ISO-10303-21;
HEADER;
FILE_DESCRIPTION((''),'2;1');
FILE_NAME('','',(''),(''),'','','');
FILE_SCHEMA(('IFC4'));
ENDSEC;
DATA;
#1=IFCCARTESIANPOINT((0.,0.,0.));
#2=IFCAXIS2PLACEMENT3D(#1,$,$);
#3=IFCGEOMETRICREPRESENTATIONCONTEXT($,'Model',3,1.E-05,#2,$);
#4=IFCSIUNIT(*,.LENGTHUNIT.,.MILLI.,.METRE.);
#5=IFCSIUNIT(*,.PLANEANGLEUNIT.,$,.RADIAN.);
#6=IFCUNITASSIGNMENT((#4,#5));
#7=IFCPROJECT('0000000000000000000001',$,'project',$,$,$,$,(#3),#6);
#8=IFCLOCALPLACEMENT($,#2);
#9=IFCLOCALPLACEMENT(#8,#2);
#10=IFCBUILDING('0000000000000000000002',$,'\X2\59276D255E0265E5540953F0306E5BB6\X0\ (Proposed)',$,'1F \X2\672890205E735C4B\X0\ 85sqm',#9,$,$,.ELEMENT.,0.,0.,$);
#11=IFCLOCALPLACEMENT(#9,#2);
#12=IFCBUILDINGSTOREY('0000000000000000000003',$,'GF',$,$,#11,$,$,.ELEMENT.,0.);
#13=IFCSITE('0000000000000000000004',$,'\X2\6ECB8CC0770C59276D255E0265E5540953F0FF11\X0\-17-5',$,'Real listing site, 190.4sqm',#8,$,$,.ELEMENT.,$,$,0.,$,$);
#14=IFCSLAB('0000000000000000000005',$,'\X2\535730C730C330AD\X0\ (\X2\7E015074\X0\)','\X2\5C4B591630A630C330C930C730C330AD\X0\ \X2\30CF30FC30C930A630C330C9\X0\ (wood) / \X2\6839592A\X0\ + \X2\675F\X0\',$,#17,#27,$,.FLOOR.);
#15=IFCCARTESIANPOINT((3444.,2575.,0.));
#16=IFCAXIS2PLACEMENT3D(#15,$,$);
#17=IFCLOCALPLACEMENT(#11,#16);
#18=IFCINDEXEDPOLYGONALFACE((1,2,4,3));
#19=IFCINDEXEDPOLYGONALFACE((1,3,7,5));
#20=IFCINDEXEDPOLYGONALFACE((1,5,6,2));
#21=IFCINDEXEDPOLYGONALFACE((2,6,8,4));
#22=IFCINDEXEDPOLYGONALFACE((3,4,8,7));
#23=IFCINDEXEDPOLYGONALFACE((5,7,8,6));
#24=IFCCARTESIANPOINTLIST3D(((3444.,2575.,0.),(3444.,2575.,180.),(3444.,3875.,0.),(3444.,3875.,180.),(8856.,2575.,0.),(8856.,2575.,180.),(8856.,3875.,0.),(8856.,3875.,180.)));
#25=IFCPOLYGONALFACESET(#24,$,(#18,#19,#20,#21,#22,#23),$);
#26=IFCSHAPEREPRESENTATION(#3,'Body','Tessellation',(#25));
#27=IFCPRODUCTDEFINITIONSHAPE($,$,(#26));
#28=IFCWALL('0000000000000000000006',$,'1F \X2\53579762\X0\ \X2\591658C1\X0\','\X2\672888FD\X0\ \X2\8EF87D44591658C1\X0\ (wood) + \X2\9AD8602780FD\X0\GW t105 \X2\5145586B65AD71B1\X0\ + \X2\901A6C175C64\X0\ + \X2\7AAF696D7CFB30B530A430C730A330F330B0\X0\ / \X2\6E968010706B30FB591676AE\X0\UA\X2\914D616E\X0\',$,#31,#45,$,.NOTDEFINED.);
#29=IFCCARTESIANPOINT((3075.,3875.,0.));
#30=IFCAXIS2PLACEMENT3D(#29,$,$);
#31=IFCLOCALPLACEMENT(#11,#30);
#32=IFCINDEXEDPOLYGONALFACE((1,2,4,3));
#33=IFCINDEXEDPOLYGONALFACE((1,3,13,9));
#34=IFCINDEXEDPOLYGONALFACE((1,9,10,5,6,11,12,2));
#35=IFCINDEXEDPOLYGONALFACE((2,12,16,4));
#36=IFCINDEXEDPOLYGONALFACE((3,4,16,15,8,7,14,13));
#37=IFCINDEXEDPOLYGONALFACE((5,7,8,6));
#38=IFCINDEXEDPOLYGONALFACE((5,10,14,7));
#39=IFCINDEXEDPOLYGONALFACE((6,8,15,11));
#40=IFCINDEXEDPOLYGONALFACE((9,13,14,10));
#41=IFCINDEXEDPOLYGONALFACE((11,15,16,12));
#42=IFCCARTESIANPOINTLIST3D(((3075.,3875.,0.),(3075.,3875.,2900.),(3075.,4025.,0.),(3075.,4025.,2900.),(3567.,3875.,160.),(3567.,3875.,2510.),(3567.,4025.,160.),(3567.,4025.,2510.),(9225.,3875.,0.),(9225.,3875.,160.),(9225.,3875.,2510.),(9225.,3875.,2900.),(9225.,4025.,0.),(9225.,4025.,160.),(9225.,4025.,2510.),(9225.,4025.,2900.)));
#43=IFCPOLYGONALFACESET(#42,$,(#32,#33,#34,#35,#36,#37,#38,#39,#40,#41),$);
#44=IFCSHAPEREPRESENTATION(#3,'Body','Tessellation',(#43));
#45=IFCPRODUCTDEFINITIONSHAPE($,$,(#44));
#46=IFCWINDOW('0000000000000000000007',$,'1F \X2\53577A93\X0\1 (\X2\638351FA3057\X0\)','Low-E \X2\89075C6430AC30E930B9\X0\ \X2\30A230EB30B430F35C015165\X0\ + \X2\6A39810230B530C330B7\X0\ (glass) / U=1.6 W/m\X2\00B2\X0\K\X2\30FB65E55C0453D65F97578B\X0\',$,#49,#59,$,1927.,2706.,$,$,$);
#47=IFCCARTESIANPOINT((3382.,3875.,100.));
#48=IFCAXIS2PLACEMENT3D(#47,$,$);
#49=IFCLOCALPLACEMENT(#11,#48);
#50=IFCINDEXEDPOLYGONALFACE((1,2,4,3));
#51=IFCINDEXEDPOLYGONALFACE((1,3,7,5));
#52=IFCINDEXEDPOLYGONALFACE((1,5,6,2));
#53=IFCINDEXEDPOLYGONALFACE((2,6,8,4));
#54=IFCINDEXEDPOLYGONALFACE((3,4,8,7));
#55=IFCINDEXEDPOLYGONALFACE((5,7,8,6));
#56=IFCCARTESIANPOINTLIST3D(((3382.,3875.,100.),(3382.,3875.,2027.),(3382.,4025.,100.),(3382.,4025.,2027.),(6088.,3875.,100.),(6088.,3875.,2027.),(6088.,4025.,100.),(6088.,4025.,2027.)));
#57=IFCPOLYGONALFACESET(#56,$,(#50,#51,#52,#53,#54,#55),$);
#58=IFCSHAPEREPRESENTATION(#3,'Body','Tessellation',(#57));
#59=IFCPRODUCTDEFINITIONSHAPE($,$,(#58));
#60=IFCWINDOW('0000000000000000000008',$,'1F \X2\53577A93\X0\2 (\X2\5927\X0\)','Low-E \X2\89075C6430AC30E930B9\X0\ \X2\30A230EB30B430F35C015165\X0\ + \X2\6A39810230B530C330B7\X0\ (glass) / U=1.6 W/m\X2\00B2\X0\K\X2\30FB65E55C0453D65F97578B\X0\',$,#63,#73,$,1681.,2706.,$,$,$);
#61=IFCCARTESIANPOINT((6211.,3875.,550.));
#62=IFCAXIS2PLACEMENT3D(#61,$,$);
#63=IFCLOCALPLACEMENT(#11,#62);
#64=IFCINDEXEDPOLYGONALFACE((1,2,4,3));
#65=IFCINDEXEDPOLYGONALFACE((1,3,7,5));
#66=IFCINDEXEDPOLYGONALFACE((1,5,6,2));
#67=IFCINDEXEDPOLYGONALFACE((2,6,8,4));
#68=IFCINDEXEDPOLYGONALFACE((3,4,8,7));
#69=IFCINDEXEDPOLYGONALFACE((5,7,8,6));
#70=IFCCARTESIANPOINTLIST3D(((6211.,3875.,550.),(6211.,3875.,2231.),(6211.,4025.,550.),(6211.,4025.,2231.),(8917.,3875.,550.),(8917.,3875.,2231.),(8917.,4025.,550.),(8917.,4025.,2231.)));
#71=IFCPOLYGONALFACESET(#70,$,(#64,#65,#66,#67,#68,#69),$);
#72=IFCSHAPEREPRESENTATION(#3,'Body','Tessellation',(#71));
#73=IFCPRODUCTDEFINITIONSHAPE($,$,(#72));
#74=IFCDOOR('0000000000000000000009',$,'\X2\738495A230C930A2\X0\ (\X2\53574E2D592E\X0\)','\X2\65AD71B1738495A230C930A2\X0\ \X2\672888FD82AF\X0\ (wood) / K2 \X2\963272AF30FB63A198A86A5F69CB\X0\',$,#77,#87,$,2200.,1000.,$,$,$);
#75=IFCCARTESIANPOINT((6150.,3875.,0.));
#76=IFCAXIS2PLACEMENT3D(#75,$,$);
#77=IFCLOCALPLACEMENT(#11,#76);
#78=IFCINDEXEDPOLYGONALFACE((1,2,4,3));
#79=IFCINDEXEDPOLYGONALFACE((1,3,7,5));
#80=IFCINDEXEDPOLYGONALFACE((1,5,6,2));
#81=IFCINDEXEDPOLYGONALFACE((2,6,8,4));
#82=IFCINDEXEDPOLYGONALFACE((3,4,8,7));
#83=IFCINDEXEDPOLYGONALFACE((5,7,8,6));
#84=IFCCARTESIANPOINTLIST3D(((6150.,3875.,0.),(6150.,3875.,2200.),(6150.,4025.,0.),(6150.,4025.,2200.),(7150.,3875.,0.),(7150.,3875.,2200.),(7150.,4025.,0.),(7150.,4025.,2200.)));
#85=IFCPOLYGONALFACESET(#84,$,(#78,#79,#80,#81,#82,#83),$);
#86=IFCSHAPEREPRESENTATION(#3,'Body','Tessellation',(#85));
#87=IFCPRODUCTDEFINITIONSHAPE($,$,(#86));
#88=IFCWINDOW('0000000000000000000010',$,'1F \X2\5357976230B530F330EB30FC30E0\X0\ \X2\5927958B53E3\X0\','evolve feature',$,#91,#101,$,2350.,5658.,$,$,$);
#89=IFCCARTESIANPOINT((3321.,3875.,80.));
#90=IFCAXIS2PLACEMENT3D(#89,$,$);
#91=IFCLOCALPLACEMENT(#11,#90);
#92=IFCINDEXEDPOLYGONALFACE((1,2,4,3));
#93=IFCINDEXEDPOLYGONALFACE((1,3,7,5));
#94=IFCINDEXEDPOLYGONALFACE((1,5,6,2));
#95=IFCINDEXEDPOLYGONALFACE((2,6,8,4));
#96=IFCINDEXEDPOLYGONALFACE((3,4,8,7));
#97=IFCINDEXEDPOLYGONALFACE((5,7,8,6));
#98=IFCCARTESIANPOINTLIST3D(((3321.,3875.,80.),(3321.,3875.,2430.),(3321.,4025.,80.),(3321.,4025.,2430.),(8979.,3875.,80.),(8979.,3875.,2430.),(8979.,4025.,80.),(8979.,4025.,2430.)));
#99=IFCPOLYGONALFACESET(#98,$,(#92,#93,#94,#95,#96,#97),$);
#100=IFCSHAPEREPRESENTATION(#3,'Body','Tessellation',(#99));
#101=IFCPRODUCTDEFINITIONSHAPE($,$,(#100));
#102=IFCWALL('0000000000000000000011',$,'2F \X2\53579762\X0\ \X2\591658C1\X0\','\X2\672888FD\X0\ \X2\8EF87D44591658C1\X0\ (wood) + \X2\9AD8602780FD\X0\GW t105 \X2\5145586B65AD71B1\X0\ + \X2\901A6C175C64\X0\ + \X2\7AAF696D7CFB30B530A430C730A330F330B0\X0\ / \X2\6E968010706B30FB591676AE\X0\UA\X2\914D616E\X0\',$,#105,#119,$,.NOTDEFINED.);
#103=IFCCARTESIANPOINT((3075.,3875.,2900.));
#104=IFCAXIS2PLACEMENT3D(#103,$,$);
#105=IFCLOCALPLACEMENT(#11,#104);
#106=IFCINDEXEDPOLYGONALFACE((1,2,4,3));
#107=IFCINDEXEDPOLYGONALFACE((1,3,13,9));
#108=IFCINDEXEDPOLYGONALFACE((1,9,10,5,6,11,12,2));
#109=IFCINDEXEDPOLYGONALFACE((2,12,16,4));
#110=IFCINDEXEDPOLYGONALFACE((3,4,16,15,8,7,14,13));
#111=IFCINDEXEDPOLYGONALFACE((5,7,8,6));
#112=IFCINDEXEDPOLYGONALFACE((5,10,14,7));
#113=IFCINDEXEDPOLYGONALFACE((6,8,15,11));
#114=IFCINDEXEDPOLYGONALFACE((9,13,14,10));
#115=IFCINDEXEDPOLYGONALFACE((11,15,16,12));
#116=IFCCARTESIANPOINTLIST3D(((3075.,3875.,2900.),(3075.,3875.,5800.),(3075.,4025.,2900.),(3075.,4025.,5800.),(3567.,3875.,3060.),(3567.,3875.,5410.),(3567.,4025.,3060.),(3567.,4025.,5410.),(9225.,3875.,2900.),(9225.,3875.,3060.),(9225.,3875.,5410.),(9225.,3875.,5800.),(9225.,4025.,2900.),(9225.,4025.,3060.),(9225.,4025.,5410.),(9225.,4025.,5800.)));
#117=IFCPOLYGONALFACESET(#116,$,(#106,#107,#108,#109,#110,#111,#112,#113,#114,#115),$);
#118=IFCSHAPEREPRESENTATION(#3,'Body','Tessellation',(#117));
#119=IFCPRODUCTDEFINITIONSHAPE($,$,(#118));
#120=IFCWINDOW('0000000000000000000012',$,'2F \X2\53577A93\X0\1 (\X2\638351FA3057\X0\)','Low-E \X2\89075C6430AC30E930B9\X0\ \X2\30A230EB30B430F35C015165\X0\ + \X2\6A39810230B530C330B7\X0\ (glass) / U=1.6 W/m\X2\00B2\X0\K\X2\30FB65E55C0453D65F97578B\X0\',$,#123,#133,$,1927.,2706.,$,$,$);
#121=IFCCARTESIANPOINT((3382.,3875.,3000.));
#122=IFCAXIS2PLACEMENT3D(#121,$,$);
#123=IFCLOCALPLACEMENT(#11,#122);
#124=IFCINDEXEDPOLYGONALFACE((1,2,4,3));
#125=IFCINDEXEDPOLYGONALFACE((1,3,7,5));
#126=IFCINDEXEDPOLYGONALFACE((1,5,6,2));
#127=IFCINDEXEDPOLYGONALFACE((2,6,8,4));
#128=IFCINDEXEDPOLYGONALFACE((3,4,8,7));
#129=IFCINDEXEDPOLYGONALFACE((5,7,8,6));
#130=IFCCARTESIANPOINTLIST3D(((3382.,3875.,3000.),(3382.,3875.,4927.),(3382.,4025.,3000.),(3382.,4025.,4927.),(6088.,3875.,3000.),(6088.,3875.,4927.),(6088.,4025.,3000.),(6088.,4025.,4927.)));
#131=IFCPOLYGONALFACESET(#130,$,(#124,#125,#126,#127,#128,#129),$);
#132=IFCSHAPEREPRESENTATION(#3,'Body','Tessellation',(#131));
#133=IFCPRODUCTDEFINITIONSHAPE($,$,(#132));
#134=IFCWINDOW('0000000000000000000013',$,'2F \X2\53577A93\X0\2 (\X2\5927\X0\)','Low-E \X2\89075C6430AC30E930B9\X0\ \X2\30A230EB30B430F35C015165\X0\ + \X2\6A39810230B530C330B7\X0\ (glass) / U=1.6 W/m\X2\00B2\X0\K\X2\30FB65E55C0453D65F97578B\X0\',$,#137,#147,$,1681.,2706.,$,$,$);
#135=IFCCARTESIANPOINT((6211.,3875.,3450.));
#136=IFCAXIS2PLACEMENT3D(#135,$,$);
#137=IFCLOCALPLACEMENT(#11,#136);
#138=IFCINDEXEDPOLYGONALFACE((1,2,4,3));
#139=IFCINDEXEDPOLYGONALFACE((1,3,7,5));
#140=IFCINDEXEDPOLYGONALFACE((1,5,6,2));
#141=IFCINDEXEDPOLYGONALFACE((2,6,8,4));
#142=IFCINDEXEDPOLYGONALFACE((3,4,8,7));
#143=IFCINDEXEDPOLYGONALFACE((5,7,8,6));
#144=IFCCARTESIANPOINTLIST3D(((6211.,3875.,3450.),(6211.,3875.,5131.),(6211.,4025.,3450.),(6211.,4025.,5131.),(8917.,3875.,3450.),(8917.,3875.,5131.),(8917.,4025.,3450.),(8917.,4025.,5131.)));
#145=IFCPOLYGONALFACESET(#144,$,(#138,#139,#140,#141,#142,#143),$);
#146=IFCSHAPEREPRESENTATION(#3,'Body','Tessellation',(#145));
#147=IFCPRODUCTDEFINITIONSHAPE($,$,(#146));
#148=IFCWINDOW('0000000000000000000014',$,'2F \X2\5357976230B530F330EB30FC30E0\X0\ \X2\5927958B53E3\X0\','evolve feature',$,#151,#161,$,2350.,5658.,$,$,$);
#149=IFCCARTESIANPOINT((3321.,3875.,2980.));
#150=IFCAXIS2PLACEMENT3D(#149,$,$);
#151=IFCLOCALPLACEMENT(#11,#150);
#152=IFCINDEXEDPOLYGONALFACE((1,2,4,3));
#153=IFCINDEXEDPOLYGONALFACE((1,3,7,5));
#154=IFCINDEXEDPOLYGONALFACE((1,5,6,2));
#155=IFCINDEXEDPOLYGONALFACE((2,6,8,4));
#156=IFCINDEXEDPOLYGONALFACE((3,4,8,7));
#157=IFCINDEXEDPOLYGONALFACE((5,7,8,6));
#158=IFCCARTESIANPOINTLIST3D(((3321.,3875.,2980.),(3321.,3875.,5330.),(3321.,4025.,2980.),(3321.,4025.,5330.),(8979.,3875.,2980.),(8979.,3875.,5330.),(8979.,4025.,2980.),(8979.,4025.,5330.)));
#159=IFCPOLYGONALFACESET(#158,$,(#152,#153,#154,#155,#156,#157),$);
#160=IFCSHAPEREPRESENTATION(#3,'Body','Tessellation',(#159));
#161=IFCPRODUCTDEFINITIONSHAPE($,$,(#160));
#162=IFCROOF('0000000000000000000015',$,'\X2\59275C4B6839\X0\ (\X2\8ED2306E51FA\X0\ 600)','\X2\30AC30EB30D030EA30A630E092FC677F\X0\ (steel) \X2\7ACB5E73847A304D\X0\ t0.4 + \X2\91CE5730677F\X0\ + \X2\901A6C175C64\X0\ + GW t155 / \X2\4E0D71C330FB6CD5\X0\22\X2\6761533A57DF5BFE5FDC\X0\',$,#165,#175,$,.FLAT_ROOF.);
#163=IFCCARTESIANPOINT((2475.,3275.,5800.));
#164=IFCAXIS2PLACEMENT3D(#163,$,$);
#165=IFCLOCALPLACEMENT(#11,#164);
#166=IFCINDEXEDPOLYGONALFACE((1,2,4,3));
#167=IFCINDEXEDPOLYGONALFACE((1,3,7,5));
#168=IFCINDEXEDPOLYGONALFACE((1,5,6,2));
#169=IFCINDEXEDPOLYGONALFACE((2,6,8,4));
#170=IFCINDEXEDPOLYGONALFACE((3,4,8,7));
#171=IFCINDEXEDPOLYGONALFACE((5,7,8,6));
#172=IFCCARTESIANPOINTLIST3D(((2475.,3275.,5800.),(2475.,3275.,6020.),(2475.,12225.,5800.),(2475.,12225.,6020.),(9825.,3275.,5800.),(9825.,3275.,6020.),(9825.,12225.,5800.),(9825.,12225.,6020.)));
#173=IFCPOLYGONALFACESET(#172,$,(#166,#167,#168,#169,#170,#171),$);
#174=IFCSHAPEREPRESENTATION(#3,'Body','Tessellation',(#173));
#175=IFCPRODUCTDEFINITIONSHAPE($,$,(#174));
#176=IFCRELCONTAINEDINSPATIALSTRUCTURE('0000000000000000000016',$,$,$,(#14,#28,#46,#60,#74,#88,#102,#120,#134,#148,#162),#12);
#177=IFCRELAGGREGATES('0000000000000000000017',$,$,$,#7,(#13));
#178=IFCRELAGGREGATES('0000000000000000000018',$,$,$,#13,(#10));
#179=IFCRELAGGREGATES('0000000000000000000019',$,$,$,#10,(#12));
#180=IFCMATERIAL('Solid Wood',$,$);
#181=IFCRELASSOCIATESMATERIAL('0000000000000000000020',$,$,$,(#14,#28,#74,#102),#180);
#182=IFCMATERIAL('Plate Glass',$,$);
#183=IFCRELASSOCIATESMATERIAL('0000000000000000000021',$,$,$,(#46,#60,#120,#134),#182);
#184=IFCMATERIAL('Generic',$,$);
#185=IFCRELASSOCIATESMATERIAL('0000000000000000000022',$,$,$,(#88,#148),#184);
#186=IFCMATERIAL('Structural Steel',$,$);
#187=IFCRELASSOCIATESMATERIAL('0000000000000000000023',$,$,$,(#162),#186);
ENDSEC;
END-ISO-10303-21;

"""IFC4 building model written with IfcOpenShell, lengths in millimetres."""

from ifc_helpers import new_model, si_unit, frame, frame_2d, origin, place, context, project, spatial, rectangle, extrude, material, element, fill, save


model = new_model("IFC4")

# Units and contexts
model_context = context("Model", 3, precision=1e-05, world=origin())
ifc_project = project(units=[si_unit("LENGTHUNIT", "METRE", prefix="MILLI"), si_unit("PLANEANGLEUNIT", "RADIAN")], contexts=[model_context])

# Site, building, storey
site_placement = place(None, origin())
site = spatial("IfcSite", under=ifc_project, at=site_placement, Name="滋賀県大津市日吉台１-17-5", ObjectType="Real listing site, 190.4sqm", CompositionType="ELEMENT", RefElevation=0.0)
building_placement = place(site_placement, origin())
building = spatial("IfcBuilding", under=site, at=building_placement, Name="大津市日吉台の家 (Proposed)", ObjectType="1F 木造平屋 85sqm", CompositionType="ELEMENT", ElevationOfRefHeight=0.0, ElevationOfTerrain=0.0)
storey_placement = place(building_placement, origin())
storey = spatial("IfcBuildingStorey", under=building, at=storey_placement, Name="GF", CompositionType="ELEMENT", Elevation=0.0)

# Slab
ifc_material_1 = material(Name="Solid Wood")
slab_1_placement = place(storey_placement, frame((3444.0, 2575.0, 0.0)))
element("IfcSlab", 1, at=slab_1_placement, inside=storey, material=ifc_material_1, Name="南デッキ (縁側)", Description="屋外ウッドデッキ ハードウッド (wood) / 根太 + 束", PredefinedType="FLOOR", context=model_context, shape_type="SweptSolid", body=[
    extrude(rectangle(XDim=5412.0, YDim=1300.0, at=frame_2d((2706.0, 650.0))), frame((3444.0, 2575.0, 0.0)), (0.0, 0.0, 1.0), 180.0),
])
ifc_material_2 = material(Name="Generic")

# Wall, openings, windows, door
wall_1_placement = place(storey_placement, frame((3075.0, 3875.0, 0.0)))
wall_1 = element("IfcWall", 2, at=wall_1_placement, inside=storey, material=ifc_material_1, Name="1F 南面 外壁", Description="木製 軸組外壁 (wood) + 高性能GW t105 充填断熱 + 通気層 + 窯業系サイディング / 準耐火・外皮UA配慮", PredefinedType="NOTDEFINED", context=model_context, shape_type="SweptSolid", body=[
    extrude(rectangle(XDim=6150.0, YDim=150.0, at=frame_2d((3075.0, 75.0))), frame((3075.0, 3875.0, 0.0)), (0.0, 0.0, 1.0), 2900.0),
])
opening_1_placement = place(storey_placement, frame((3382.0, 3875.0, 100.0)))
opening_1 = element("IfcOpeningElement", 3, at=opening_1_placement, cuts=wall_1, PredefinedType="NOTDEFINED", context=model_context, shape_type="SweptSolid", body=[
    extrude(rectangle(XDim=2706.0, YDim=150.0, at=frame_2d((1353.0, 75.0))), frame((3382.0, 3875.0, 100.0)), (0.0, 0.0, 1.0), 1927.0),
])
opening_2_placement = place(storey_placement, frame((6211.0, 3875.0, 550.0)))
opening_2 = element("IfcOpeningElement", 4, at=opening_2_placement, cuts=wall_1, PredefinedType="NOTDEFINED", context=model_context, shape_type="SweptSolid", body=[
    extrude(rectangle(XDim=2706.0, YDim=150.0, at=frame_2d((1353.0, 75.0))), frame((6211.0, 3875.0, 550.0)), (0.0, 0.0, 1.0), 1681.0),
])
opening_3_placement = place(storey_placement, frame((6150.0, 3875.0, 0.0)))
opening_3 = element("IfcOpeningElement", 5, at=opening_3_placement, cuts=wall_1, PredefinedType="NOTDEFINED", context=model_context, shape_type="SweptSolid", body=[
    extrude(rectangle(XDim=1000.0, YDim=150.0, at=frame_2d((500.0, 75.0))), frame((6150.0, 3875.0, 0.0)), (0.0, 0.0, 1.0), 2200.0),
])
opening_4_placement = place(storey_placement, frame((3321.0, 3875.0, 80.0)))
opening_4 = element("IfcOpeningElement", 6, at=opening_4_placement, cuts=wall_1, PredefinedType="NOTDEFINED", context=model_context, shape_type="SweptSolid", body=[
    extrude(rectangle(XDim=5658.0, YDim=150.0, at=frame_2d((2829.0, 75.0))), frame((3321.0, 3875.0, 80.0)), (0.0, 0.0, 1.0), 2350.0),
])
ifc_material_3 = material(Name="Plate Glass")
window_1_placement = place(storey_placement, frame((3382.0, 3875.0, 100.0)))
window_1 = element("IfcWindow", 7, at=window_1_placement, inside=storey, material=ifc_material_3, Name="1F 南窓1 (掃出し)", Description="Low-E 複層ガラス アルゴン封入 + 樹脂サッシ (glass) / U=1.6 W/m²K・日射取得型", OverallHeight=1927.0, OverallWidth=2706.0, context=model_context, shape_type="SweptSolid", body=[
    extrude(rectangle(XDim=2706.0, YDim=150.0, at=frame_2d((1353.0, 75.0))), frame((3382.0, 3875.0, 100.0)), (0.0, 0.0, 1.0), 1927.0),
])
fill(opening_1, window_1)
window_2_placement = place(storey_placement, frame((6211.0, 3875.0, 550.0)))
window_2 = element("IfcWindow", 8, at=window_2_placement, inside=storey, material=ifc_material_3, Name="1F 南窓2 (大)", Description="Low-E 複層ガラス アルゴン封入 + 樹脂サッシ (glass) / U=1.6 W/m²K・日射取得型", OverallHeight=1681.0, OverallWidth=2706.0, context=model_context, shape_type="SweptSolid", body=[
    extrude(rectangle(XDim=2706.0, YDim=150.0, at=frame_2d((1353.0, 75.0))), frame((6211.0, 3875.0, 550.0)), (0.0, 0.0, 1.0), 1681.0),
])
fill(opening_2, window_2)
door_placement = place(storey_placement, frame((6150.0, 3875.0, 0.0)))
door = element("IfcDoor", 9, at=door_placement, inside=storey, material=ifc_material_1, Name="玄関ドア (南中央)", Description="断熱玄関ドア 木製芯 (wood) / K2 防犯・採風機構", OverallHeight=2200.0, OverallWidth=1000.0, context=model_context, shape_type="SweptSolid", body=[
    extrude(rectangle(XDim=1000.0, YDim=150.0, at=frame_2d((500.0, 75.0))), frame((6150.0, 3875.0, 0.0)), (0.0, 0.0, 1.0), 2200.0),
])
fill(opening_3, door)
window_3_placement = place(storey_placement, frame((3321.0, 3875.0, 80.0)))
window_3 = element("IfcWindow", 10, at=window_3_placement, inside=storey, material=ifc_material_2, Name="1F 南面サンルーム 大開口", Description="evolve feature", OverallHeight=2350.0, OverallWidth=5658.0, context=model_context, shape_type="SweptSolid", body=[
    extrude(rectangle(XDim=5658.0, YDim=150.0, at=frame_2d((2829.0, 75.0))), frame((3321.0, 3875.0, 80.0)), (0.0, 0.0, 1.0), 2350.0),
])
fill(opening_4, window_3)

# Wall, openings, windows
wall_2_placement = place(storey_placement, frame((3075.0, 3875.0, 2900.0)))
wall_2 = element("IfcWall", 11, at=wall_2_placement, inside=storey, material=ifc_material_1, Name="2F 南面 外壁", Description="木製 軸組外壁 (wood) + 高性能GW t105 充填断熱 + 通気層 + 窯業系サイディング / 準耐火・外皮UA配慮", PredefinedType="NOTDEFINED", context=model_context, shape_type="SweptSolid", body=[
    extrude(rectangle(XDim=6150.0, YDim=150.0, at=frame_2d((3075.0, 75.0))), frame((3075.0, 3875.0, 2900.0)), (0.0, 0.0, 1.0), 2900.0),
])
opening_5_placement = place(storey_placement, frame((3382.0, 3875.0, 3000.0)))
opening_5 = element("IfcOpeningElement", 12, at=opening_5_placement, cuts=wall_2, PredefinedType="NOTDEFINED", context=model_context, shape_type="SweptSolid", body=[
    extrude(rectangle(XDim=2706.0, YDim=150.0, at=frame_2d((1353.0, 75.0))), frame((3382.0, 3875.0, 3000.0)), (0.0, 0.0, 1.0), 1927.0),
])
opening_6_placement = place(storey_placement, frame((6211.0, 3875.0, 3450.0)))
opening_6 = element("IfcOpeningElement", 13, at=opening_6_placement, cuts=wall_2, PredefinedType="NOTDEFINED", context=model_context, shape_type="SweptSolid", body=[
    extrude(rectangle(XDim=2706.0, YDim=150.0, at=frame_2d((1353.0, 75.0))), frame((6211.0, 3875.0, 3450.0)), (0.0, 0.0, 1.0), 1681.0),
])
opening_7_placement = place(storey_placement, frame((3321.0, 3875.0, 2980.0)))
opening_7 = element("IfcOpeningElement", 14, at=opening_7_placement, cuts=wall_2, PredefinedType="NOTDEFINED", context=model_context, shape_type="SweptSolid", body=[
    extrude(rectangle(XDim=5658.0, YDim=150.0, at=frame_2d((2829.0, 75.0))), frame((3321.0, 3875.0, 2980.0)), (0.0, 0.0, 1.0), 2350.0),
])
window_4_placement = place(storey_placement, frame((3382.0, 3875.0, 3000.0)))
window_4 = element("IfcWindow", 15, at=window_4_placement, inside=storey, material=ifc_material_3, Name="2F 南窓1 (掃出し)", Description="Low-E 複層ガラス アルゴン封入 + 樹脂サッシ (glass) / U=1.6 W/m²K・日射取得型", OverallHeight=1927.0, OverallWidth=2706.0, context=model_context, shape_type="SweptSolid", body=[
    extrude(rectangle(XDim=2706.0, YDim=150.0, at=frame_2d((1353.0, 75.0))), frame((3382.0, 3875.0, 3000.0)), (0.0, 0.0, 1.0), 1927.0),
])
fill(opening_5, window_4)
window_5_placement = place(storey_placement, frame((6211.0, 3875.0, 3450.0)))
window_5 = element("IfcWindow", 16, at=window_5_placement, inside=storey, material=ifc_material_3, Name="2F 南窓2 (大)", Description="Low-E 複層ガラス アルゴン封入 + 樹脂サッシ (glass) / U=1.6 W/m²K・日射取得型", OverallHeight=1681.0, OverallWidth=2706.0, context=model_context, shape_type="SweptSolid", body=[
    extrude(rectangle(XDim=2706.0, YDim=150.0, at=frame_2d((1353.0, 75.0))), frame((6211.0, 3875.0, 3450.0)), (0.0, 0.0, 1.0), 1681.0),
])
fill(opening_6, window_5)
window_6_placement = place(storey_placement, frame((3321.0, 3875.0, 2980.0)))
window_6 = element("IfcWindow", 17, at=window_6_placement, inside=storey, material=ifc_material_2, Name="2F 南面サンルーム 大開口", Description="evolve feature", OverallHeight=2350.0, OverallWidth=5658.0, context=model_context, shape_type="SweptSolid", body=[
    extrude(rectangle(XDim=5658.0, YDim=150.0, at=frame_2d((2829.0, 75.0))), frame((3321.0, 3875.0, 2980.0)), (0.0, 0.0, 1.0), 2350.0),
])
fill(opening_7, window_6)

# Roof
ifc_material_4 = material(Name="Structural Steel")
roof_placement = place(storey_placement, frame((2475.0, 3275.0, 5800.0)))
element("IfcRoof", 18, at=roof_placement, inside=storey, material=ifc_material_4, Name="大屋根 (軒の出 600)", Description="ガルバリウム鋼板 (steel) 立平葺き t0.4 + 野地板 + 通気層 + GW t155 / 不燃・法22条区域対応", PredefinedType="FLAT_ROOF", context=model_context, shape_type="SweptSolid", body=[
    extrude(rectangle(XDim=7350.0, YDim=8950.0, at=frame_2d((3675.0, 4475.0))), frame((2475.0, 3275.0, 5800.0)), (0.0, 0.0, 1.0), 220.0),
])

save(model, "model.ifc")
